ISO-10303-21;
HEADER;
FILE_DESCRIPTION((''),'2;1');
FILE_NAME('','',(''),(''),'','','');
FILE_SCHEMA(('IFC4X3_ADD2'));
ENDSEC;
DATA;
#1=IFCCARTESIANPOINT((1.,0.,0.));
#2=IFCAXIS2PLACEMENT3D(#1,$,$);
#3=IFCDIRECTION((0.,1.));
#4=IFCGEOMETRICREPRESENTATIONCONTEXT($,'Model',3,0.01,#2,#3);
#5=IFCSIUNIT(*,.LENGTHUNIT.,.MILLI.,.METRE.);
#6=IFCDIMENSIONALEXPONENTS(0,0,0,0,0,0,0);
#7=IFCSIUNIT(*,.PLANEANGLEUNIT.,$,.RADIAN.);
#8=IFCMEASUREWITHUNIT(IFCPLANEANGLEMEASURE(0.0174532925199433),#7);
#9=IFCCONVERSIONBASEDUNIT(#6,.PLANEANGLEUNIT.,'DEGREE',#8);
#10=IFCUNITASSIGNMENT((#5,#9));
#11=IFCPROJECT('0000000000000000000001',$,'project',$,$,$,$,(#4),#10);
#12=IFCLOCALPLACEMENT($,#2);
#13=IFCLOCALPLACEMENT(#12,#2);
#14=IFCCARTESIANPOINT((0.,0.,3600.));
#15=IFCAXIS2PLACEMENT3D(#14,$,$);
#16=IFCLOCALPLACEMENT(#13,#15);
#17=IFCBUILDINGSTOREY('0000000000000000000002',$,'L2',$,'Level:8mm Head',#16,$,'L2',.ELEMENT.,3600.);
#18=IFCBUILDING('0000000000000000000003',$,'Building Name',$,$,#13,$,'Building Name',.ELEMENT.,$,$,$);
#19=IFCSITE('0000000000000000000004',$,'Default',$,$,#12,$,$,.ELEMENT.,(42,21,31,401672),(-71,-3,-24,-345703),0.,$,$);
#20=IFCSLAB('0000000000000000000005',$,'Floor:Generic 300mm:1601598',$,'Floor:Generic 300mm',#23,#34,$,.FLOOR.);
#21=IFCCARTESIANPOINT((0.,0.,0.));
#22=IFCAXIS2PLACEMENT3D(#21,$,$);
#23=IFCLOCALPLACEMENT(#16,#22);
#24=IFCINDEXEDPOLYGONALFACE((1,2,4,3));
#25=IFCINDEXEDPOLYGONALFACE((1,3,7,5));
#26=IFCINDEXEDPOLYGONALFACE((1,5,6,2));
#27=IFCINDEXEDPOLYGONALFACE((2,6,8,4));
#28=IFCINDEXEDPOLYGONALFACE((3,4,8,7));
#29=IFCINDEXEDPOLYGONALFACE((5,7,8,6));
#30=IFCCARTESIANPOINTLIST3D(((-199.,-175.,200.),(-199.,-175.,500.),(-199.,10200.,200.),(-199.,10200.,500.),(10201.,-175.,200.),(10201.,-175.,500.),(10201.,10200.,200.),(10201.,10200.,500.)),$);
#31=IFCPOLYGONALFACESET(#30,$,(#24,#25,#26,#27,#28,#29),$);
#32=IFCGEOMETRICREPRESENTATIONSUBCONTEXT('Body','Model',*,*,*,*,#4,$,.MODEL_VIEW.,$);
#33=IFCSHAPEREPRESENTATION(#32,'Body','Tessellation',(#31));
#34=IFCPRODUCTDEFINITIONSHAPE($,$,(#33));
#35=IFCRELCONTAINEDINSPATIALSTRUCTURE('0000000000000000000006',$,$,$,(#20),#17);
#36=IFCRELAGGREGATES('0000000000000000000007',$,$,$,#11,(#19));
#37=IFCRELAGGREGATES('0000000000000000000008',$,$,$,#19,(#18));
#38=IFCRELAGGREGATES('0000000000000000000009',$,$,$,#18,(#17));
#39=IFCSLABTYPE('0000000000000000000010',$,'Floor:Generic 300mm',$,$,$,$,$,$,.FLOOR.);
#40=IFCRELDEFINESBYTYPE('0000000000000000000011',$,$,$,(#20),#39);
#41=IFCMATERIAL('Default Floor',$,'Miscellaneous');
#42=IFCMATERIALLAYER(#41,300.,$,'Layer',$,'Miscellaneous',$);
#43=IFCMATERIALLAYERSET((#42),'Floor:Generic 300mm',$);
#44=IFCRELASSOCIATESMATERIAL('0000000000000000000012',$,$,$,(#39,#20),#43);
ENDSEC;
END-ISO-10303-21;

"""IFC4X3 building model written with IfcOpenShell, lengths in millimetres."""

from ifc_helpers import new_model, entity, si_unit, converted_unit, direction, frame, frame_2d, place, context, subcontext, project, spatial, rectangle, extrude, material, layer, layer_set, layer_usage, type_object, element, save


model = new_model("IFC4X3")

# Units and contexts
model_context = context("Model", 3, precision=0.01, world=frame((1.0, 0.0, 0.0)), true_north=direction((0.0, 1.0)))
body_context = subcontext(model_context, "Body", "Model", "MODEL_VIEW")
ifc_project = project(units=[si_unit("LENGTHUNIT", "METRE", prefix="MILLI"), converted_unit("PLANEANGLEUNIT", "DEGREE", entity("IfcPlaneAngleMeasure", 0.0174532925199433), si_unit("PLANEANGLEUNIT", "RADIAN"), dimensions=[0, 0, 0, 0, 0, 0, 0])], contexts=[model_context])

# Site, building, storey
site_placement = place(None, frame((1.0, 0.0, 0.0)))
site = spatial("IfcSite", under=ifc_project, at=site_placement, Name="Default", CompositionType="ELEMENT", RefLatitude=(42, 21, 31, 401672), RefLongitude=(-71, -3, -24, -345703), RefElevation=0.0)
building_placement = place(site_placement, frame((1.0, 0.0, 0.0)))
building = spatial("IfcBuilding", under=site, at=building_placement, Name="Building Name", LongName="Building Name", CompositionType="ELEMENT")
storey_placement = place(building_placement, frame((0.0, 0.0, 3600.0)))
storey = spatial("IfcBuildingStorey", under=building, at=storey_placement, Name="L2", ObjectType="Level:8mm Head", LongName="L2", CompositionType="ELEMENT", Elevation=3600.0)

# Slab
ifc_material = material(Name="Default Floor", Category="Miscellaneous")
ifc_layer = layer(ifc_material, 300.0, Name="Layer", Category="Miscellaneous")
ifc_layer_set = layer_set([ifc_layer], Name="Floor:Generic 300mm")
ifc_layer_usage = layer_usage(ifc_layer_set, "AXIS3", "POSITIVE", 0.0)
slab_type = type_object("IfcSlabType", Name="Floor:Generic 300mm", PredefinedType="FLOOR", material=ifc_layer_set)
slab_placement = place(storey_placement, frame((1.0, 0.0, 0.0)))
element("IfcSlab", 1, at=slab_placement, inside=storey, type_object=slab_type, material=ifc_layer_usage, Name="Floor:Generic 300mm:1601598", ObjectType="Floor:Generic 300mm", PredefinedType="FLOOR", context=body_context, shape_type="SweptSolid", body=[
    extrude(rectangle(XDim=10375.0, YDim=10400.0, at=frame_2d((0.0, 0.0), x_axis=(1.0, 0.0))), frame((5000.0, 5012.5, 500.0), z_axis=(0.0, 0.0, -1.0), x_axis=(0.0, 1.0, 0.0)), (0.0, 0.0, 1.0), 300.0),
])

save(model, "model.ifc")
